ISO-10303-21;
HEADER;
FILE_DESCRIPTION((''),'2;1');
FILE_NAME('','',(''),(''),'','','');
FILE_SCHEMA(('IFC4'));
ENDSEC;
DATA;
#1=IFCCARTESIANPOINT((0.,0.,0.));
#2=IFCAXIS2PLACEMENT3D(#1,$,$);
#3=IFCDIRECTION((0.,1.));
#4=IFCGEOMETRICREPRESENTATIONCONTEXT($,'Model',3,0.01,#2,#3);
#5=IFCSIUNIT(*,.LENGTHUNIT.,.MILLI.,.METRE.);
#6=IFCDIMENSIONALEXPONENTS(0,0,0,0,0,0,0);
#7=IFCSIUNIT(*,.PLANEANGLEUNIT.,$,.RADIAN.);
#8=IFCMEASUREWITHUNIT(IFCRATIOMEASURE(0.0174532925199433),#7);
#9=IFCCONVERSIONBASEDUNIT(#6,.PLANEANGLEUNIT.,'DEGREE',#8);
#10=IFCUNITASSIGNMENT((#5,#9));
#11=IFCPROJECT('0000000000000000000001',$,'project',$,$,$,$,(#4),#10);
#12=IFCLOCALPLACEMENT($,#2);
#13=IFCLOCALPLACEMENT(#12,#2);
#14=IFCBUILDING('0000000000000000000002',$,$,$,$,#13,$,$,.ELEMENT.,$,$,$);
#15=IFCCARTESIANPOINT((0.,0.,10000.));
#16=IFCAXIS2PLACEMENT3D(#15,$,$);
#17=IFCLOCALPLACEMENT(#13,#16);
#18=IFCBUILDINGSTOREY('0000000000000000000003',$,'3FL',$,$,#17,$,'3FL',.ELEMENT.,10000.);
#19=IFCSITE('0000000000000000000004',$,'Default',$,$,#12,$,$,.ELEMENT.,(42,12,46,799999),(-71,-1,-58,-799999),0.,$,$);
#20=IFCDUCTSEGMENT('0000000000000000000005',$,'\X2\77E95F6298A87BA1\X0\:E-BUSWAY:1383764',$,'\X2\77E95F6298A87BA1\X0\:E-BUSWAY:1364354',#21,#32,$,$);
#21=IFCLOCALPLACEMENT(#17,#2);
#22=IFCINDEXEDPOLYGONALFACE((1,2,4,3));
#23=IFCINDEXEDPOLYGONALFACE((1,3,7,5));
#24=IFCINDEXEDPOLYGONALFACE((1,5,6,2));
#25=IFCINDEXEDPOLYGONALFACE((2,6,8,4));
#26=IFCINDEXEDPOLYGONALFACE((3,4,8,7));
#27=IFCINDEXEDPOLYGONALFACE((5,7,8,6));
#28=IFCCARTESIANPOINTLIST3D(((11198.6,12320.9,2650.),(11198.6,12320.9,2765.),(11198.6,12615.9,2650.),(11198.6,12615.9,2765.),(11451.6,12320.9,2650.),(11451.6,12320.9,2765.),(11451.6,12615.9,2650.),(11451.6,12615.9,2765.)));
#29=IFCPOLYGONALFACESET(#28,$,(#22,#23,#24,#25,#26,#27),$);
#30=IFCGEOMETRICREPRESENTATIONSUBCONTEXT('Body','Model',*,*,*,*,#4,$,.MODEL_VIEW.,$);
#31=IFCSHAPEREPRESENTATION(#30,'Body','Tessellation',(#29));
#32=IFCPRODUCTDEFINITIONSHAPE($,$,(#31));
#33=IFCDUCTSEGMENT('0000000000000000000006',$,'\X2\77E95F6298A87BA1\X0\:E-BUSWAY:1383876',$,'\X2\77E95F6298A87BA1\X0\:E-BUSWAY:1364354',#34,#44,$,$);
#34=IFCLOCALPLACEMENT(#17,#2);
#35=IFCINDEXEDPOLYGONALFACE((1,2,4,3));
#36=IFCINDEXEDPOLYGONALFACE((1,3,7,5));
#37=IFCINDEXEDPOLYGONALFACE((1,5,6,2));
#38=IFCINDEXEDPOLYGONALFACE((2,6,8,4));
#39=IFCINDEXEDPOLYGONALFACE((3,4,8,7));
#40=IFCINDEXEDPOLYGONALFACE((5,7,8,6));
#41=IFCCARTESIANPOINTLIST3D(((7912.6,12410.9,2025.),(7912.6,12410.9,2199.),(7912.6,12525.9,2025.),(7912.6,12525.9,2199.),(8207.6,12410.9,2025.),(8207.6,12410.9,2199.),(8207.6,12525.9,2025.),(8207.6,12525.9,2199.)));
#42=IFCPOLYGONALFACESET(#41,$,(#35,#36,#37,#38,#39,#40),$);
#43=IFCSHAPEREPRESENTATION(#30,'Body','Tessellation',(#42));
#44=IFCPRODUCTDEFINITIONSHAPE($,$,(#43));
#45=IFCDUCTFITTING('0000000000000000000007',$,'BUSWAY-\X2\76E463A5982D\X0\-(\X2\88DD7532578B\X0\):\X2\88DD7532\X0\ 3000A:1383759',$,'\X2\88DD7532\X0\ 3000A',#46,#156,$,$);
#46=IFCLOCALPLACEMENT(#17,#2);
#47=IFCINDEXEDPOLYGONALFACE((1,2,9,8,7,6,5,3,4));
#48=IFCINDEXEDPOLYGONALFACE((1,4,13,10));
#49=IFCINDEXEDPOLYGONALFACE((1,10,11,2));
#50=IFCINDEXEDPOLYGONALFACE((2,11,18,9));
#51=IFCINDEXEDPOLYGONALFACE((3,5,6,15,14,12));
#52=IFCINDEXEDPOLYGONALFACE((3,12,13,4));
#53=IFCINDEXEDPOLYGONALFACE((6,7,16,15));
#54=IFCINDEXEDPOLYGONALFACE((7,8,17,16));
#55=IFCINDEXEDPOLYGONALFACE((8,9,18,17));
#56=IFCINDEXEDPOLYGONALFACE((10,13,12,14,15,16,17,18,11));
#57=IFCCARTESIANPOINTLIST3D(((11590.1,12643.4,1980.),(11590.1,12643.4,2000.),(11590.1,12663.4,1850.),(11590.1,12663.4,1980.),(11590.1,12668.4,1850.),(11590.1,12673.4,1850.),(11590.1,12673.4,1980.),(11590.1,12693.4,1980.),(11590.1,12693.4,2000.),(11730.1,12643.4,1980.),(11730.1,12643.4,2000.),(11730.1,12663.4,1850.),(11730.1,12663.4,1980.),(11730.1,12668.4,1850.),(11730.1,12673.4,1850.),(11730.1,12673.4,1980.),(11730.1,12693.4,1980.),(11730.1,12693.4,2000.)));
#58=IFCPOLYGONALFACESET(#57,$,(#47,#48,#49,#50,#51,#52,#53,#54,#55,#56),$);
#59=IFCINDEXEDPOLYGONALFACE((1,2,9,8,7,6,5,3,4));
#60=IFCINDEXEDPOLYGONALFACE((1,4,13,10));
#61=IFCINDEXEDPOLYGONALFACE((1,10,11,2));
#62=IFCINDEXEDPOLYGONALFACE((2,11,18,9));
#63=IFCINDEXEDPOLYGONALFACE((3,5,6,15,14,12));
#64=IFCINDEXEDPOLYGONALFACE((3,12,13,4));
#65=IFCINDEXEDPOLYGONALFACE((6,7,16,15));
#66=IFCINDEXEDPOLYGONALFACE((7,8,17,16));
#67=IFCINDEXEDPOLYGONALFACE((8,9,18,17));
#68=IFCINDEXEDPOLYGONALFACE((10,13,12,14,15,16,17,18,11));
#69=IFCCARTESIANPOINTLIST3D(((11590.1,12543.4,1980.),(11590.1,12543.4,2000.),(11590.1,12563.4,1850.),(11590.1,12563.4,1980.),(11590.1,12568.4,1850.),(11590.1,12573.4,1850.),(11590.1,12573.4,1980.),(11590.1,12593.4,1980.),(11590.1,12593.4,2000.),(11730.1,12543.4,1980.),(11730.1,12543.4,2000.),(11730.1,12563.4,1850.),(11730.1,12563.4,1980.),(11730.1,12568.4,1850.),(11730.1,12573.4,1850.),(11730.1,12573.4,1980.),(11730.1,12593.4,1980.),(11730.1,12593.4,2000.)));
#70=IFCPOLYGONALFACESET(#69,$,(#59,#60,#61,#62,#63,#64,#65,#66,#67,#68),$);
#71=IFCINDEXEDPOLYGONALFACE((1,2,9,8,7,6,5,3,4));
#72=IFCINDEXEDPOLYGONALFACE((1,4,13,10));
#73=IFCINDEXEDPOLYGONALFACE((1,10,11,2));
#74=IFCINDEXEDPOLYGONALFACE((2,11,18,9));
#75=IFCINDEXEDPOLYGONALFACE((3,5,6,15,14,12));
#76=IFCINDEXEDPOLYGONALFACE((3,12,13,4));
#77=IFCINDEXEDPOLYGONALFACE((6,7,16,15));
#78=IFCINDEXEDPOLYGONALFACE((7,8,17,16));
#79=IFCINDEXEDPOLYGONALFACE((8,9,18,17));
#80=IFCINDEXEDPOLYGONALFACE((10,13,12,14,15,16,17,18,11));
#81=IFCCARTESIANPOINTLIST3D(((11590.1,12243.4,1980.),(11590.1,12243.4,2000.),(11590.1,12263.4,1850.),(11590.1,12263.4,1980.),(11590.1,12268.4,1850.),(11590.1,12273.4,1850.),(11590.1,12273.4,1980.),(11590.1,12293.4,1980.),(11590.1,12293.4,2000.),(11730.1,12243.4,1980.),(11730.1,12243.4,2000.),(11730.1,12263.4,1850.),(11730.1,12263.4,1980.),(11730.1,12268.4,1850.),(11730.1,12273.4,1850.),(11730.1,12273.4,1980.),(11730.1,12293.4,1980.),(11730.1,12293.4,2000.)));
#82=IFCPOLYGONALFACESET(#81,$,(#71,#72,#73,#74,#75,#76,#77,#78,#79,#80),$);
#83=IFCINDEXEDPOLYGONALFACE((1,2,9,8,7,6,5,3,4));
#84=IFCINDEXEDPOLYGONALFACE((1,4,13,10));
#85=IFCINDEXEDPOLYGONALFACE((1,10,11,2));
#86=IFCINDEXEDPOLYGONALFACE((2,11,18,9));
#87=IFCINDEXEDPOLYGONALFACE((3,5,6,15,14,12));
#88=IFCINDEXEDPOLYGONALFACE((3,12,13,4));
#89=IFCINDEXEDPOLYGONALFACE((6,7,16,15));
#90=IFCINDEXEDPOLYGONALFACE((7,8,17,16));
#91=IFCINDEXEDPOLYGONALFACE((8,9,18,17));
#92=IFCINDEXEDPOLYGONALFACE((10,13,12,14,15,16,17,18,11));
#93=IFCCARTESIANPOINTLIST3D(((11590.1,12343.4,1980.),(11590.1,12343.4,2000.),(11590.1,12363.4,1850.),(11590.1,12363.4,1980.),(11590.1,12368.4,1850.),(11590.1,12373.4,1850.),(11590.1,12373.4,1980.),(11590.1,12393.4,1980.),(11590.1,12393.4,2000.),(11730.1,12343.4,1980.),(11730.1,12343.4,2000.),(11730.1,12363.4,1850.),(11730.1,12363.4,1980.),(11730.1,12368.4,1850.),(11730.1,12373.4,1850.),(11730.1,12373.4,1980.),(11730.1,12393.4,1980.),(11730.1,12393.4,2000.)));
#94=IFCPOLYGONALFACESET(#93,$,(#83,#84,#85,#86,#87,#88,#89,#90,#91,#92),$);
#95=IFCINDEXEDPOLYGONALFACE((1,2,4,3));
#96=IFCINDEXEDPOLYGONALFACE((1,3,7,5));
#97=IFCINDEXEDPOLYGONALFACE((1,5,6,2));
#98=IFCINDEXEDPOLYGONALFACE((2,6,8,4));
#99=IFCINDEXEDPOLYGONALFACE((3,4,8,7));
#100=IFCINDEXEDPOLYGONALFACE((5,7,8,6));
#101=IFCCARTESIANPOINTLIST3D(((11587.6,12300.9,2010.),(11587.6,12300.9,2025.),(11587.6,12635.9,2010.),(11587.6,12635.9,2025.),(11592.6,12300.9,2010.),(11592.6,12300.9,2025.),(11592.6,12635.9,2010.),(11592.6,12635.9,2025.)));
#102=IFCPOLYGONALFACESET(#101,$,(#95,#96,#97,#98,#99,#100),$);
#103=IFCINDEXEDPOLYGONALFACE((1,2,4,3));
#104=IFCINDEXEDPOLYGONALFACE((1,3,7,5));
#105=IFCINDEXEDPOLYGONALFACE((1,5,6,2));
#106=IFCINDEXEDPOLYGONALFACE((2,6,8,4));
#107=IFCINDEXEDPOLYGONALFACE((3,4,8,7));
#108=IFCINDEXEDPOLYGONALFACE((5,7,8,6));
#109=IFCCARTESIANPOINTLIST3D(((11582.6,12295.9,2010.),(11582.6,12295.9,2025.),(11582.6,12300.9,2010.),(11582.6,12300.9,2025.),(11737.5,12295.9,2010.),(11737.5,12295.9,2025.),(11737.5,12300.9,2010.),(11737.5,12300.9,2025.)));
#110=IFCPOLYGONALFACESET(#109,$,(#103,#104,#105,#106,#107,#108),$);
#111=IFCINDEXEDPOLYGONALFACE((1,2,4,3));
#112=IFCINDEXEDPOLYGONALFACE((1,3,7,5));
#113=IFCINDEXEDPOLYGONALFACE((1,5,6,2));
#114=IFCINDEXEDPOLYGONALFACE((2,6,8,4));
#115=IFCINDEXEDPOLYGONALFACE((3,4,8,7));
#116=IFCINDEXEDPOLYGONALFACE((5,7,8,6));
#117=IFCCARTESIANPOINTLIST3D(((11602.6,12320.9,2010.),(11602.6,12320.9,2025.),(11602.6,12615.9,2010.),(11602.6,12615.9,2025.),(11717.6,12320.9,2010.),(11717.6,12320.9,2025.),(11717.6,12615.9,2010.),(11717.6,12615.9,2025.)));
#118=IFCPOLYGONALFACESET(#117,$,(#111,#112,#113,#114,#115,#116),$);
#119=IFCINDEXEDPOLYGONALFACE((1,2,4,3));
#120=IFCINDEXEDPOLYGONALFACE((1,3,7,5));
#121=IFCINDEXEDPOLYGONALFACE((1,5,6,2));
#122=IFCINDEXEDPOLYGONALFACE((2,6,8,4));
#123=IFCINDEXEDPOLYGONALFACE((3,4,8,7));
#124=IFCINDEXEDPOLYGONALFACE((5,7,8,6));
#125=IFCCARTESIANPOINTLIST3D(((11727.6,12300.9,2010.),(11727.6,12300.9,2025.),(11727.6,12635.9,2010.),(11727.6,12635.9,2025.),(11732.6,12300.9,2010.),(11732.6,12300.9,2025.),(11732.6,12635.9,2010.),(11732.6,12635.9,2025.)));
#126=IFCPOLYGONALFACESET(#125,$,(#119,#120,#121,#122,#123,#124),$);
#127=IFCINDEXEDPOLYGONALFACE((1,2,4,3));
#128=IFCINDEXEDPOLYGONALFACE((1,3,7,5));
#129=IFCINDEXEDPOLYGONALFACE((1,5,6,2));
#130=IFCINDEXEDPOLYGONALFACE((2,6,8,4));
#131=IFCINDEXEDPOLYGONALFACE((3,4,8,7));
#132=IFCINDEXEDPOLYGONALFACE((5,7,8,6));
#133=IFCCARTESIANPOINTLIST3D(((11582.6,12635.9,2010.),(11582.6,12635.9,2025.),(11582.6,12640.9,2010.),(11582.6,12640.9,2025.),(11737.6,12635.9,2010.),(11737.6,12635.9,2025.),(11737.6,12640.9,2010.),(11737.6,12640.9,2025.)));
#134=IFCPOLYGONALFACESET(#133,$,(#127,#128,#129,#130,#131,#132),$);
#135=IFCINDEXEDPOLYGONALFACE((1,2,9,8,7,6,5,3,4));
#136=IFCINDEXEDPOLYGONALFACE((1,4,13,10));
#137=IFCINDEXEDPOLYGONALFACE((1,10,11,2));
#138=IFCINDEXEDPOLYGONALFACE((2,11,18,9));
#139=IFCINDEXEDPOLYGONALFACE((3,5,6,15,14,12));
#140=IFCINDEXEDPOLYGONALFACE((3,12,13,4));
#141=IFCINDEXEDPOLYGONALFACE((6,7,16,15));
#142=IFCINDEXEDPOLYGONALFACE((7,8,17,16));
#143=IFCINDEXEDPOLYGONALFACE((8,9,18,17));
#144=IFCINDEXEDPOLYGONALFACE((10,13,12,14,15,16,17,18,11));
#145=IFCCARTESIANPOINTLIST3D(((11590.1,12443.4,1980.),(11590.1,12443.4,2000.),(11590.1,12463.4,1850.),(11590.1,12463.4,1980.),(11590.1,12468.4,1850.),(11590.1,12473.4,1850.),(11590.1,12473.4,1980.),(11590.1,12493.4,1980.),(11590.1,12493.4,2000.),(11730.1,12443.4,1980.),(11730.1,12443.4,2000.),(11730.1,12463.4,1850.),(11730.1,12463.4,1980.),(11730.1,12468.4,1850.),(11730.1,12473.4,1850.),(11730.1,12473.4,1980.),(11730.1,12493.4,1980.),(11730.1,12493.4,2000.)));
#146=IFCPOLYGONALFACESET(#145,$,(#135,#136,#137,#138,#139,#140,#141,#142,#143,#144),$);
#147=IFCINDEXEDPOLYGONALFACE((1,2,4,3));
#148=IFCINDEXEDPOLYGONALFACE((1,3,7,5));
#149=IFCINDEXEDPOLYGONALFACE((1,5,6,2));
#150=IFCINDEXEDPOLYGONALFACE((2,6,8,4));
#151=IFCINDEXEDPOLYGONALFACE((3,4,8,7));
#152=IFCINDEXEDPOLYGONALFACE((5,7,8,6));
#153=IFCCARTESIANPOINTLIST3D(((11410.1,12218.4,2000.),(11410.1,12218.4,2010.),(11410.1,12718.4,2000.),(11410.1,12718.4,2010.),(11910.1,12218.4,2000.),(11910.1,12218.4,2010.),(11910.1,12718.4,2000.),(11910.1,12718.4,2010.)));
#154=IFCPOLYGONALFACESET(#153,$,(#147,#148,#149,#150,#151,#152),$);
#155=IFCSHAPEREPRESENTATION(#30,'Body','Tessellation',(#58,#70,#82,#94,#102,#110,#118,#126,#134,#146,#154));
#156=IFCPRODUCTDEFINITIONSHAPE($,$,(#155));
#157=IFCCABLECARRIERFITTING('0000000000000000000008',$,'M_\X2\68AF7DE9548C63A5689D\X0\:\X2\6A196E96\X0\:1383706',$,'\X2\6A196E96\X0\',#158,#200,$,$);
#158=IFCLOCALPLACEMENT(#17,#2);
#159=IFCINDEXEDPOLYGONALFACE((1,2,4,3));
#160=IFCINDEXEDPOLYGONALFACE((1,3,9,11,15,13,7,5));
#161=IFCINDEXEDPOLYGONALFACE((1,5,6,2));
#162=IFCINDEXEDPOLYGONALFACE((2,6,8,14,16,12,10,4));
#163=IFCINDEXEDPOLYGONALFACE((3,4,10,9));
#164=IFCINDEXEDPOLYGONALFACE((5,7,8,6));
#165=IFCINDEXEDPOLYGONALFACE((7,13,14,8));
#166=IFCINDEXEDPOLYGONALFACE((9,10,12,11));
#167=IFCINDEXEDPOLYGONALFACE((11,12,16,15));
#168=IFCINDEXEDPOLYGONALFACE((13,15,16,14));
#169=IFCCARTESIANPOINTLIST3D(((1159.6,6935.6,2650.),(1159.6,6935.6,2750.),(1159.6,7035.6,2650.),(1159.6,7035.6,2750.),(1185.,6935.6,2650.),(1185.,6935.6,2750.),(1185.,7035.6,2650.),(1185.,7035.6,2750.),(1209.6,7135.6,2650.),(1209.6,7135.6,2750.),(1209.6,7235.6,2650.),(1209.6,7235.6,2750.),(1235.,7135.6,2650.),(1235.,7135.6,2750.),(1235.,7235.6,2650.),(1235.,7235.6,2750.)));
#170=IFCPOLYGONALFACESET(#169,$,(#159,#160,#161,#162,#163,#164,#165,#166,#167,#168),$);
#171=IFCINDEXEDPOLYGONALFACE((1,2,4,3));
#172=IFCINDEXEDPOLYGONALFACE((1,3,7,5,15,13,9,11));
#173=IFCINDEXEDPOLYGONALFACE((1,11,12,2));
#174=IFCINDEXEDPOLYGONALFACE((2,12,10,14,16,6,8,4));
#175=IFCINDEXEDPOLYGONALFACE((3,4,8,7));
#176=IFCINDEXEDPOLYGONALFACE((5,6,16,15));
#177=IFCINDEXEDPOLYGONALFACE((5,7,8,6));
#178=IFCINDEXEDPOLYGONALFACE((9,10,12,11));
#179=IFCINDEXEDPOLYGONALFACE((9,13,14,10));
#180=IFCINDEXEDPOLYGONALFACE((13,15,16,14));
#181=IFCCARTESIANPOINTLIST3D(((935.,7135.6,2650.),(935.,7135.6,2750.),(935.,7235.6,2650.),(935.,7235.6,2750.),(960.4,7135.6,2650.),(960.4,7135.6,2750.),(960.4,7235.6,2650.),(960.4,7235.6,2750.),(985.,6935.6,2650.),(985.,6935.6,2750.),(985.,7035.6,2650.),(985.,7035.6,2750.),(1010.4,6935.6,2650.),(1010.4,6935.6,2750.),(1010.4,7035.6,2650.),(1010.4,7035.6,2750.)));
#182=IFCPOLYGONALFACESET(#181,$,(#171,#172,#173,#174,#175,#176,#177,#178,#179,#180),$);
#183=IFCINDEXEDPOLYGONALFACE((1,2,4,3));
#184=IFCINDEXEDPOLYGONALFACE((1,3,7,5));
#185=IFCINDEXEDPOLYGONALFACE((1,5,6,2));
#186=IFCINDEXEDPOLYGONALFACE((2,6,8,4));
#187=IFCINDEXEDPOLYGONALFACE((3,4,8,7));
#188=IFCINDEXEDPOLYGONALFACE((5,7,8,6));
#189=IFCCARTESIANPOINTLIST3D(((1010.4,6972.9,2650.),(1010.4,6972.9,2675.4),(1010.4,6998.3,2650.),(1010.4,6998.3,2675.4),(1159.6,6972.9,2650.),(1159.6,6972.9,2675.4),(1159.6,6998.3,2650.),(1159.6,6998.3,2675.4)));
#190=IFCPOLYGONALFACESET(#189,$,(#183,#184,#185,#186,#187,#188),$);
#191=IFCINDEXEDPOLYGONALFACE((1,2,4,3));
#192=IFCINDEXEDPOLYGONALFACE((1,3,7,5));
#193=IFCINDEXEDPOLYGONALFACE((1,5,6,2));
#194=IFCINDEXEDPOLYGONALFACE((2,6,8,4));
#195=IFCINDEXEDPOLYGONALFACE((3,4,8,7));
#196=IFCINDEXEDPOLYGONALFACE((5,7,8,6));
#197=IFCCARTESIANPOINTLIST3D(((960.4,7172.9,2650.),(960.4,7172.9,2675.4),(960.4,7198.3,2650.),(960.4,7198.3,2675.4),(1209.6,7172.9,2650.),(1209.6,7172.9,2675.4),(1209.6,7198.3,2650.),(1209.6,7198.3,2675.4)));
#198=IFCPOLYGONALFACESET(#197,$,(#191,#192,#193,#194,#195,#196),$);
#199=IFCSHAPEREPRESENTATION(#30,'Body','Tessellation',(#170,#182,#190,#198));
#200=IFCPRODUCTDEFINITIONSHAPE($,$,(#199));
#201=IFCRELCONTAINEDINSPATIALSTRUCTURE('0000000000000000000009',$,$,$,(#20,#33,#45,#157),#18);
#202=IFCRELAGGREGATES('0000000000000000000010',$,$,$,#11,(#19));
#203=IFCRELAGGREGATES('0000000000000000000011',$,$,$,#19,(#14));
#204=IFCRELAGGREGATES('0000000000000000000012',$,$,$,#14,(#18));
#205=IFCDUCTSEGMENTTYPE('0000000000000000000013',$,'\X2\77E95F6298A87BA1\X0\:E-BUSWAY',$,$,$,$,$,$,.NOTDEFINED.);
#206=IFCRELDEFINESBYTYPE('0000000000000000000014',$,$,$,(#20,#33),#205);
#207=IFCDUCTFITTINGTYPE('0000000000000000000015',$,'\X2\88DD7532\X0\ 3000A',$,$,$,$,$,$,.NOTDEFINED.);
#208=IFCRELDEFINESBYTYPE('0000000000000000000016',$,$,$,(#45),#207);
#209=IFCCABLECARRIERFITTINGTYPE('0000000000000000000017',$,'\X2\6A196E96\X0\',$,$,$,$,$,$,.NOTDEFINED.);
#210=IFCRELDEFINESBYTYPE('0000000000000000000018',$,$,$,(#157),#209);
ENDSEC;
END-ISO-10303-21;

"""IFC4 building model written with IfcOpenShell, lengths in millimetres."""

from ifc_helpers import new_model, entity, si_unit, converted_unit, direction, frame, frame_2d, origin, origin_2d_with_axis, place, context, subcontext, project, spatial, polyline, rectangle, outline, extrude, source, transform, mapped, type_object, type_shapes, element, save


model = new_model("IFC4")

# Units and contexts
model_context = context("Model", 3, precision=0.01, world=origin(), true_north=direction((0.0, 1.0)))
body_context = subcontext(model_context, "Body", "Model", "MODEL_VIEW")
ifc_project = project(units=[si_unit("LENGTHUNIT", "METRE", prefix="MILLI"), converted_unit("PLANEANGLEUNIT", "DEGREE", entity("IfcRatioMeasure", 0.0174532925199433), si_unit("PLANEANGLEUNIT", "RADIAN"), dimensions=[0, 0, 0, 0, 0, 0, 0])], contexts=[model_context])

# Site, building, storey
site_placement = place(None, origin())
site = spatial("IfcSite", under=ifc_project, at=site_placement, Name="Default", CompositionType="ELEMENT", RefLatitude=(42, 12, 46, 799999), RefLongitude=(-71, -1, -58, -799999), RefElevation=0.0)
building_placement = place(site_placement, origin())
building = spatial("IfcBuilding", under=site, at=building_placement, CompositionType="ELEMENT")
storey_placement = place(building_placement, frame((0.0, 0.0, 10000.0)))
storey = spatial("IfcBuildingStorey", under=building, at=storey_placement, Name="3FL", LongName="3FL", CompositionType="ELEMENT", Elevation=10000.0)

# Duct segments
duct_segment_type = type_object("IfcDuctSegmentType", Name="矩形風管:E-BUSWAY", PredefinedType="NOTDEFINED")
duct_segment_1_placement = place(storey_placement, frame((11198.6, 12320.9, 2650.0)))
element("IfcDuctSegment", 1, at=duct_segment_1_placement, inside=storey, type_object=duct_segment_type, Name="矩形風管:E-BUSWAY:1383764", ObjectType="矩形風管:E-BUSWAY:1364354", context=body_context, shape_type="SweptSolid", body=[
    extrude(rectangle(XDim=253.0, YDim=295.0, at=frame_2d((0.0, 0.0), x_axis=(1.0, 0.0))), frame((126.5, 147.5, 0.0)), (0.0, 0.0, 1.0), 115.0),
])
duct_segment_2_placement = place(storey_placement, frame((7912.6, 12410.9, 2025.0)))
element("IfcDuctSegment", 2, at=duct_segment_2_placement, inside=storey, type_object=duct_segment_type, Name="矩形風管:E-BUSWAY:1383876", ObjectType="矩形風管:E-BUSWAY:1364354", context=body_context, shape_type="SweptSolid", body=[
    extrude(rectangle(XDim=115.0, YDim=295.0, at=frame_2d((0.0, 0.0), x_axis=(1.0, 0.0))), frame((147.5, 57.5, 0.0), z_axis=(0.0, 0.0, 1.0), x_axis=(0.0, -1.0, 0.0)), (0.0, 0.0, 1.0), 174.0),
])

# Duct fitting
duct_fitting_type_1 = type_object("IfcDuctFittingType", Name="裝甲 3000A", PredefinedType="NOTDEFINED")
shared_shape_1 = source(origin(), body_context, "Body", "SweptSolid", [
    extrude(outline(polyline([(-25.0, -58.9), (25.0, -58.9), (25.0, -38.9), (5.0, -38.9), (5.0, 91.1), (0.0, 91.1), (-5.0, 91.1), (-5.0, -38.9), (-25.0, -38.9), (-25.0, -58.9)])), frame((-200.0, -70.0, -58.9), z_axis=(0.0, 1.0, 0.0), x_axis=(1.0, 0.0, 0.0)), (0.0, 0.0, 1.0), 140.0),
    extrude(outline(polyline([(-25.0, -58.9), (25.0, -58.9), (25.0, -38.9), (5.0, -38.9), (5.0, 91.1), (0.0, 91.1), (-5.0, 91.1), (-5.0, -38.9), (-25.0, -38.9), (-25.0, -58.9)])), frame((-100.0, -70.0, -58.9), z_axis=(0.0, 1.0, 0.0), x_axis=(1.0, 0.0, 0.0)), (0.0, 0.0, 1.0), 140.0),
    extrude(outline(polyline([(-58.9, -25.0), (-38.9, -25.0), (-38.9, -5.0), (91.1, -5.0), (91.1, 0.0), (91.1, 5.0), (-38.9, 5.0), (-38.9, 25.0), (-58.9, 25.0), (-58.9, -25.0)])), frame((200.0, -70.0, -58.9), z_axis=(0.0, 1.0, 0.0), x_axis=(0.0, 0.0, -1.0)), (0.0, 0.0, 1.0), 140.0),
    extrude(outline(polyline([(-58.9, -25.0), (-38.9, -25.0), (-38.9, -5.0), (91.1, -5.0), (91.1, 0.0), (91.1, 5.0), (-38.9, 5.0), (-38.9, 25.0), (-58.9, 25.0), (-58.9, -25.0)])), frame((100.0, -70.0, -58.9), z_axis=(0.0, 1.0, 0.0), x_axis=(0.0, 0.0, -1.0)), (0.0, 0.0, 1.0), 140.0),
    extrude(rectangle(XDim=335.0, YDim=5.0, at=origin_2d_with_axis()), frame((0.0, -70.0, 10.0), z_axis=(0.0, 0.0, 1.0), x_axis=(-1.0, 0.0, 0.0)), (0.0, 0.0, 1.0), 15.0),
    extrude(rectangle(XDim=5.0, YDim=154.9, at=frame_2d((0.0, 0.0), x_axis=(1.0, 0.0))), frame((170.0, -0.1, 10.0), z_axis=(0.0, 0.0, 1.0), x_axis=(-1.0, 0.0, 0.0)), (0.0, 0.0, 1.0), 15.0),
    extrude(rectangle(XDim=295.0, YDim=115.0, at=origin_2d_with_axis()), frame((0.0, 0.0, 10.0), z_axis=(0.0, 0.0, 1.0), x_axis=(-1.0, 0.0, 0.0)), (0.0, 0.0, 1.0), 15.0),
    extrude(rectangle(XDim=335.0, YDim=5.0, at=origin_2d_with_axis()), frame((0.0, 70.0, 10.0), z_axis=(0.0, 0.0, 1.0), x_axis=(-1.0, 0.0, 0.0)), (0.0, 0.0, 1.0), 15.0),
    extrude(rectangle(XDim=5.0, YDim=155.0, at=origin_2d_with_axis()), frame((-170.0, 0.0, 10.0), z_axis=(0.0, 0.0, 1.0), x_axis=(-1.0, 0.0, 0.0)), (0.0, 0.0, 1.0), 15.0),
    extrude(outline(polyline([(-58.9, -25.0), (-38.9, -25.0), (-38.9, -5.0), (91.1, -5.0), (91.1, 0.0), (91.1, 5.0), (-38.9, 5.0), (-38.9, 25.0), (-58.9, 25.0), (-58.9, -25.0)])), frame((0.0, -70.0, -58.9), z_axis=(0.0, 1.0, 0.0), x_axis=(0.0, 0.0, -1.0)), (0.0, 0.0, 1.0), 140.0),
    extrude(rectangle(XDim=500.0, YDim=500.0, at=origin_2d_with_axis()), frame((0.0, 0.0, 0.0), z_axis=(0.0, 0.0, 1.0), x_axis=(0.0, 1.0, 0.0)), (0.0, 0.0, 1.0), 10.0),
])
type_shapes(duct_fitting_type_1, [shared_shape_1])
duct_fitting_placement = place(storey_placement, frame((11660.1, 12468.4, 2000.0), z_axis=(0.0, 0.0, 1.0), x_axis=(0.0, -1.0, 0.0)))
element("IfcDuctFitting", 3, at=duct_fitting_placement, inside=storey, type_object=duct_fitting_type_1, Name="BUSWAY-盤接頭-(裝甲型):裝甲 3000A:1383759", ObjectType="裝甲 3000A", context=body_context, shape_type="MappedRepresentation", body=[
    mapped(shared_shape_1, transform((0.0, 0.0, 0.0), scale=1.0)),
])

# Cable carrier fitting
cable_carrier_fitting_type_1 = type_object("IfcCableCarrierFittingType", Name="標準", PredefinedType="NOTDEFINED")
shared_shape_2 = source(origin(), body_context, "Body", "SweptSolid", [
    extrude(outline(polyline([(-150.0, -12.3), (-150.0, -37.7), (-50.0, -37.7), (50.0, 12.3), (150.0, 12.3), (150.0, 37.7), (50.0, 37.7), (-50.0, -12.3), (-150.0, -12.3)])), frame((150.0, 112.3, -50.0), z_axis=(0.0, 0.0, -1.0), x_axis=(1.0, 0.0, 0.0)), (0.0, 0.0, -1.0), 100.0),
    extrude(outline(polyline([(-150.0, -37.7), (-50.0, -37.7), (50.0, 12.3), (150.0, 12.3), (150.0, 37.7), (50.0, 37.7), (-50.0, -12.3), (-150.0, -12.3), (-150.0, -37.7)])), frame((150.0, -112.3, -50.0)), (0.0, 0.0, 1.0), 100.0),
    extrude(rectangle(XDim=149.2, YDim=25.4, at=frame_2d((0.0, 0.0), x_axis=(1.0, 0.0))), frame((250.0, 0.0, -50.0), z_axis=(0.0, 0.0, 1.0), x_axis=(0.0, -1.0, 0.0)), (0.0, 0.0, 1.0), 25.4),
    extrude(rectangle(XDim=249.2, YDim=25.4, at=origin_2d_with_axis()), frame((50.0, 0.0, -50.0), z_axis=(0.0, 0.0, 1.0), x_axis=(0.0, -1.0, 0.0)), (0.0, 0.0, 1.0), 25.4),
])
type_shapes(cable_carrier_fitting_type_1, [shared_shape_2])
for number, where, z_axis, x_axis, name in (
    (4, (1085.0, 7235.6, 2700.0), (0.0, 0.0, 1.0), (0.0, -1.0, 0.0), "M_梯緩和接條:標準:1383706"),
):
    element("IfcCableCarrierFitting", number, at=place(storey_placement, frame(where, z_axis=z_axis, x_axis=x_axis)), inside=storey, type_object=cable_carrier_fitting_type_1, Name=name, ObjectType="標準", context=body_context, shape_type="MappedRepresentation", body=[
        mapped(shared_shape_2, transform((0.0, 0.0, 0.0), scale=1.0)),
    ])

save(model, "model.ifc")
